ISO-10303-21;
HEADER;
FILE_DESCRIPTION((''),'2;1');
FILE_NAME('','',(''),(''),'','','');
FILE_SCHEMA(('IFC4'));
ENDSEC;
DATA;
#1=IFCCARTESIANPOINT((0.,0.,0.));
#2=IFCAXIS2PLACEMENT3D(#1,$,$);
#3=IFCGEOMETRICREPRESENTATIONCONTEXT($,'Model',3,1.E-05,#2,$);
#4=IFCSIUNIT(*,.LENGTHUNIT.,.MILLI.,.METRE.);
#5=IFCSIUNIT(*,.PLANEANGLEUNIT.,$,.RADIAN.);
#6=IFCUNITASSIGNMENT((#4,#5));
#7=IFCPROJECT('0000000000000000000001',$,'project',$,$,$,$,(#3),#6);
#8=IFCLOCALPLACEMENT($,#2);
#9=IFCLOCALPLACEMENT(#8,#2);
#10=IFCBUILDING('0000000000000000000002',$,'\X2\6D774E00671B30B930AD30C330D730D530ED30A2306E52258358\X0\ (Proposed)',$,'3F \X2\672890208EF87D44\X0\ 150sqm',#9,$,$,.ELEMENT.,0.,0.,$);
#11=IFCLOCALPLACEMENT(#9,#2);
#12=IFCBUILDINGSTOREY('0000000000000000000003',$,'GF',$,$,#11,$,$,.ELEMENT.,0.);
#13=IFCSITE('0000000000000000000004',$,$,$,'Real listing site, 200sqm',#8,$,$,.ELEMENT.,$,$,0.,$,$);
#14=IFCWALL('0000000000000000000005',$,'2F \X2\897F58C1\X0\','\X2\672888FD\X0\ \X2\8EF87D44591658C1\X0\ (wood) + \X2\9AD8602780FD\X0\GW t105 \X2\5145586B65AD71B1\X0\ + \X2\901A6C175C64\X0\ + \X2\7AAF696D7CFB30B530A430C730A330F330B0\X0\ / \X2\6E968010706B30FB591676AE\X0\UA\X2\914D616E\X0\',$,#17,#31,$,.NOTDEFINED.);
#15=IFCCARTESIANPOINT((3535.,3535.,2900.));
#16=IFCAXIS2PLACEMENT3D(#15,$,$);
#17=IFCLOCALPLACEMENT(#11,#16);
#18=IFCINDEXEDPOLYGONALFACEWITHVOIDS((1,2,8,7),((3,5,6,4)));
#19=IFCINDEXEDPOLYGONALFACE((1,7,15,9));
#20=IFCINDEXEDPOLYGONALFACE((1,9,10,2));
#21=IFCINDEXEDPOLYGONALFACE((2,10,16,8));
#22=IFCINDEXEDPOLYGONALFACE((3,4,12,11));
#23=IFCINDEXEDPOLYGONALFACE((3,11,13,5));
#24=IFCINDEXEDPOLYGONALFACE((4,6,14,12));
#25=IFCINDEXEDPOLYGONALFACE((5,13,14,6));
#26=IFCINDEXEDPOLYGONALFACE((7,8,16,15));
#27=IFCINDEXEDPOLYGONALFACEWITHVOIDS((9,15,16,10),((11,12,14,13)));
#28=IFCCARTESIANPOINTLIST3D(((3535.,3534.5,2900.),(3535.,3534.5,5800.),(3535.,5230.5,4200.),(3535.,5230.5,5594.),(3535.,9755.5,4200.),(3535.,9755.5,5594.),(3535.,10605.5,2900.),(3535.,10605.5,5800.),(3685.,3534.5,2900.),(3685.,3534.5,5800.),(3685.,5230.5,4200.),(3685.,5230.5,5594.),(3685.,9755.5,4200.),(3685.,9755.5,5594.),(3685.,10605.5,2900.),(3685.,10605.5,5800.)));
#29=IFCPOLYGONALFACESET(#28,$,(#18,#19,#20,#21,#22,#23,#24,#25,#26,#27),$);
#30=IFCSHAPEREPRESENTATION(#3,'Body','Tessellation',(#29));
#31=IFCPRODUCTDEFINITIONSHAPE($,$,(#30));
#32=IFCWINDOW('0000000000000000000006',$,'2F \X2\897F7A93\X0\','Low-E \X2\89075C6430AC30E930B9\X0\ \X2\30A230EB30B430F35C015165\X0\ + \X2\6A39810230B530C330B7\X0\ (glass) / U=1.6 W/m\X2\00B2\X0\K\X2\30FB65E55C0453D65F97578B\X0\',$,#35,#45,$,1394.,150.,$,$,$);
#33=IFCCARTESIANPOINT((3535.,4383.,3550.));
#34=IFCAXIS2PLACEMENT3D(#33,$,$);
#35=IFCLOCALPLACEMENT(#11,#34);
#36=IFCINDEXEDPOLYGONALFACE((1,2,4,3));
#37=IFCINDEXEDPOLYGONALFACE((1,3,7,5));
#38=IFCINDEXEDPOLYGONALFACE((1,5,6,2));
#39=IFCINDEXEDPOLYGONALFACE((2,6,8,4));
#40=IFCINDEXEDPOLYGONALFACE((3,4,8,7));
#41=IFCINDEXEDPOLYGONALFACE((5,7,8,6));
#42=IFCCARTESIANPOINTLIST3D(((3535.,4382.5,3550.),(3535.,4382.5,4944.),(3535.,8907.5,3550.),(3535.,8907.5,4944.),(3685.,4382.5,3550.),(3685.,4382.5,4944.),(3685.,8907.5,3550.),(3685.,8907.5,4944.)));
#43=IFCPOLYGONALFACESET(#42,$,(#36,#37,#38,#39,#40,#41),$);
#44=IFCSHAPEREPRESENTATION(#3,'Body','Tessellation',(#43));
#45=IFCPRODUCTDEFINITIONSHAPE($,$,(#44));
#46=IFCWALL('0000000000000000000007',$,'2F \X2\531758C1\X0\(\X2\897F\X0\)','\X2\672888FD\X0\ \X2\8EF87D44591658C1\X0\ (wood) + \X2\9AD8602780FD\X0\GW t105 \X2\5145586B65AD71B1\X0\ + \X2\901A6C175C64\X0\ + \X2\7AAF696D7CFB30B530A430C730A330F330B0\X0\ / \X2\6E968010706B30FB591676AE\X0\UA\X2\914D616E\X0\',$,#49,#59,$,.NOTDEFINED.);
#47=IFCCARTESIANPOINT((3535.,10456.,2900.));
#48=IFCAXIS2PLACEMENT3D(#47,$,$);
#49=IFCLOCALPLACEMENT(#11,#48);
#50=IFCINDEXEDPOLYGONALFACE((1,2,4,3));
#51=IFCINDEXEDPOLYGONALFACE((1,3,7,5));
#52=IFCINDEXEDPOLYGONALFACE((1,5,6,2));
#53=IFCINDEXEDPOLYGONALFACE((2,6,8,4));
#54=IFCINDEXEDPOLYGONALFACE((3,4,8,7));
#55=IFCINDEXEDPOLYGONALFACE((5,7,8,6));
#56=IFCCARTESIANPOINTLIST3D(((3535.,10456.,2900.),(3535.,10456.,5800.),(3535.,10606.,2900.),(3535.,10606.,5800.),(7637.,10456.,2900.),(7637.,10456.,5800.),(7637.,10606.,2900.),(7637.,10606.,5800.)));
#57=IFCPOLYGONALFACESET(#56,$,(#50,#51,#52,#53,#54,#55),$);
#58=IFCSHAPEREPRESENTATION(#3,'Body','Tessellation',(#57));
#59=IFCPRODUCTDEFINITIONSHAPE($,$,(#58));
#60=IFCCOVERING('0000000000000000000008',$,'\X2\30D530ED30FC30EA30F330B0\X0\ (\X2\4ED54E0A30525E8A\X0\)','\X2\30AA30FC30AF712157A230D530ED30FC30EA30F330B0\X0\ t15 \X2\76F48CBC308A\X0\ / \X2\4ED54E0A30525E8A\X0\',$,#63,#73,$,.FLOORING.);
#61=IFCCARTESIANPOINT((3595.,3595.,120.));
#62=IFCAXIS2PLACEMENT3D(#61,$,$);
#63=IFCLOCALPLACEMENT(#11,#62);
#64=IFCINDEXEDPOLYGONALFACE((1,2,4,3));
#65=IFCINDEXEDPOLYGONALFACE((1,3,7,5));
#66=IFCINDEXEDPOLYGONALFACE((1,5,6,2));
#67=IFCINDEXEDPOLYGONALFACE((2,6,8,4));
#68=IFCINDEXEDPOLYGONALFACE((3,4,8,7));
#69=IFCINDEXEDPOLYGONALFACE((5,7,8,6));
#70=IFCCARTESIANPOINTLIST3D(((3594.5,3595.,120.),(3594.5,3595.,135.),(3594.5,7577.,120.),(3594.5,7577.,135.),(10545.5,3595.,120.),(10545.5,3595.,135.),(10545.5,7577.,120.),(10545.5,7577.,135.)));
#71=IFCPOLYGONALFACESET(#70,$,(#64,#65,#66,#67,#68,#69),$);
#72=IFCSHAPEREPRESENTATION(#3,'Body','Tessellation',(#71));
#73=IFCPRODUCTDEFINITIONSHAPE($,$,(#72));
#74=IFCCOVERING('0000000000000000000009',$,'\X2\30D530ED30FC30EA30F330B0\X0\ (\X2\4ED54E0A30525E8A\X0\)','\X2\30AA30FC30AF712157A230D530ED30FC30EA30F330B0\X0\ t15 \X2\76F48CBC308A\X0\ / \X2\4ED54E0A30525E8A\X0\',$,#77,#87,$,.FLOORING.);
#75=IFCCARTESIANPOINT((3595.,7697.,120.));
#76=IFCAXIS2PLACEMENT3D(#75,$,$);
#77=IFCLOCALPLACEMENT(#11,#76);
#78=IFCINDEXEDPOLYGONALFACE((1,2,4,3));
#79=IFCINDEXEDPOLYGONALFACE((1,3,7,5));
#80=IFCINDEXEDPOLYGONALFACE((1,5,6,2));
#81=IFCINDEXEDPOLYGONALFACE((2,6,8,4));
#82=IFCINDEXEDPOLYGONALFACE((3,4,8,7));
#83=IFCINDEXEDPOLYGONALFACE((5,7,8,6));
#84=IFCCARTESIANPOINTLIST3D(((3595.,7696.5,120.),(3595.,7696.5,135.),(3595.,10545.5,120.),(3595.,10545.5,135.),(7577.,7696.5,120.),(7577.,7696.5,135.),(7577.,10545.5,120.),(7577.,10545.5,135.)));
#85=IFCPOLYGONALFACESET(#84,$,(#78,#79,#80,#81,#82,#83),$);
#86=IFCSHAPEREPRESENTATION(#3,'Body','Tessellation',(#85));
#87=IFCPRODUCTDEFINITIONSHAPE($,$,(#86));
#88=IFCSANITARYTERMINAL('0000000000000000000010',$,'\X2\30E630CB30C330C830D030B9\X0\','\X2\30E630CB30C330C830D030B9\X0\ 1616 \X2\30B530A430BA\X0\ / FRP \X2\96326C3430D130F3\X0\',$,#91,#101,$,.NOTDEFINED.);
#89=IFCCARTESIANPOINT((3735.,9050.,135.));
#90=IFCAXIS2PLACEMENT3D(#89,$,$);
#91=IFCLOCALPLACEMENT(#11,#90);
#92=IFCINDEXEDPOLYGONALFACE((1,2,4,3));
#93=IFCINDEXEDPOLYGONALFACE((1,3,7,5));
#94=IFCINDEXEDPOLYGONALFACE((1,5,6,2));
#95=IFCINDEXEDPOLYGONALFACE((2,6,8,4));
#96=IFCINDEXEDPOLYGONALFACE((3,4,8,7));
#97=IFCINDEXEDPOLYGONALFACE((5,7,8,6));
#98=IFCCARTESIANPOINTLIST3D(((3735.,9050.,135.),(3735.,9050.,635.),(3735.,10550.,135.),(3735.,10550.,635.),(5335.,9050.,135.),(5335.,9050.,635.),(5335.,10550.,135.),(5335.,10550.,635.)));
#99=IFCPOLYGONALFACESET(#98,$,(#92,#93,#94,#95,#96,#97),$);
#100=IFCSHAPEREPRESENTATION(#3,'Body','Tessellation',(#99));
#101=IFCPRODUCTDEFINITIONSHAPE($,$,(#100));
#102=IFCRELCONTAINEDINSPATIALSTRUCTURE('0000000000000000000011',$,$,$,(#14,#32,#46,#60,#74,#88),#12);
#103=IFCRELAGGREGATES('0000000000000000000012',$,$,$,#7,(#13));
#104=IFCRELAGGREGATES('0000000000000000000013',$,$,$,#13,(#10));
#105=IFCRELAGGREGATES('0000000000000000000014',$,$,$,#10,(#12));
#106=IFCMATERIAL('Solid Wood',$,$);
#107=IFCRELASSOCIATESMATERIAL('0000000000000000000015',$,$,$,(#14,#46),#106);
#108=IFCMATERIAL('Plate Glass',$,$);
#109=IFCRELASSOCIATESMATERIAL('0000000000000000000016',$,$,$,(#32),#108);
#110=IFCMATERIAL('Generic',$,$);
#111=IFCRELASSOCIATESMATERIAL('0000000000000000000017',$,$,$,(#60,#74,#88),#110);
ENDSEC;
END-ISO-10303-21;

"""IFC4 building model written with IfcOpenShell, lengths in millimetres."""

from ifc_helpers import new_model, si_unit, frame, frame_2d, origin, place, context, project, spatial, rectangle, extrude, material, element, fill, save


model = new_model("IFC4")

# Units and contexts
model_context = context("Model", 3, precision=1e-05, world=origin())
ifc_project = project(units=[si_unit("LENGTHUNIT", "METRE", prefix="MILLI"), si_unit("PLANEANGLEUNIT", "RADIAN")], contexts=[model_context])

# Site, building, storey
site_placement = place(None, origin())
site = spatial("IfcSite", under=ifc_project, at=site_placement, ObjectType="Real listing site, 200sqm", CompositionType="ELEMENT", RefElevation=0.0)
building_placement = place(site_placement, origin())
building = spatial("IfcBuilding", under=site, at=building_placement, Name="海一望スキップフロアの別荘 (Proposed)", ObjectType="3F 木造軸組 150sqm", CompositionType="ELEMENT", ElevationOfRefHeight=0.0, ElevationOfTerrain=0.0)
storey_placement = place(building_placement, origin())
storey = spatial("IfcBuildingStorey", under=building, at=storey_placement, Name="GF", CompositionType="ELEMENT", Elevation=0.0)

# Shared definitions
ifc_material_1 = material(Name="Solid Wood")

# Shared definitions
ifc_material_2 = material(Name="Plate Glass")

# Wall, opening, window
wall_1_placement = place(storey_placement, frame((3535.0, 3535.0, 2900.0)))
wall_1 = element("IfcWall", 1, at=wall_1_placement, inside=storey, material=ifc_material_1, Name="2F 西壁", Description="木製 軸組外壁 (wood) + 高性能GW t105 充填断熱 + 通気層 + 窯業系サイディング / 準耐火・外皮UA配慮", PredefinedType="NOTDEFINED", context=model_context, shape_type="SweptSolid", body=[
    extrude(rectangle(XDim=150.0, YDim=7071.0, at=frame_2d((75.0, 3535.0))), frame((3535.0, 3535.0, 2900.0)), (0.0, 0.0, 1.0), 2900.0),
])
opening_1_placement = place(storey_placement, frame((3535.0, 4383.0, 3550.0)))
opening_1 = element("IfcOpeningElement", 2, at=opening_1_placement, cuts=wall_1, PredefinedType="NOTDEFINED", context=model_context, shape_type="SweptSolid", body=[
    extrude(rectangle(XDim=150.0, YDim=4525.0, at=frame_2d((75.0, 2262.0))), frame((3535.0, 4383.0, 3550.0)), (0.0, 0.0, 1.0), 1394.0),
])
window_1_placement = place(storey_placement, frame((3535.0, 4383.0, 3550.0)))
window_1 = element("IfcWindow", 3, at=window_1_placement, inside=storey, material=ifc_material_2, Name="2F 西窓", Description="Low-E 複層ガラス アルゴン封入 + 樹脂サッシ (glass) / U=1.6 W/m²K・日射取得型", OverallHeight=1394.0, OverallWidth=150.0, context=model_context, shape_type="SweptSolid", body=[
    extrude(rectangle(XDim=150.0, YDim=4525.0, at=frame_2d((75.0, 2262.0))), frame((3535.0, 4383.0, 3550.0)), (0.0, 0.0, 1.0), 1394.0),
])
fill(opening_1, window_1)

# Wall
wall_2_placement = place(storey_placement, frame((3535.0, 10456.0, 2900.0)))
element("IfcWall", 4, at=wall_2_placement, inside=storey, material=ifc_material_1, Name="2F 北壁(西)", Description="木製 軸組外壁 (wood) + 高性能GW t105 充填断熱 + 通気層 + 窯業系サイディング / 準耐火・外皮UA配慮", PredefinedType="NOTDEFINED", context=model_context, shape_type="SweptSolid", body=[
    extrude(rectangle(XDim=4102.0, YDim=150.0, at=frame_2d((2051.0, 75.0))), frame((3535.0, 10456.0, 2900.0)), (0.0, 0.0, 1.0), 2900.0),
])

# Coverings
ifc_material_3 = material(Name="Generic")
covering_1_placement = place(storey_placement, frame((3595.0, 3595.0, 120.0)))
element("IfcCovering", 5, at=covering_1_placement, inside=storey, material=ifc_material_3, Name="フローリング (仕上げ床)", Description="オーク無垢フローリング t15 直貼り / 仕上げ床", PredefinedType="FLOORING", context=model_context, shape_type="SweptSolid", body=[
    extrude(rectangle(XDim=6951.0, YDim=3982.0, at=frame_2d((3475.0, 1991.0))), frame((3595.0, 3595.0, 120.0)), (0.0, 0.0, 1.0), 15.0),
])
covering_2_placement = place(storey_placement, frame((3595.0, 7697.0, 120.0)))
element("IfcCovering", 6, at=covering_2_placement, inside=storey, material=ifc_material_3, Name="フローリング (仕上げ床)", Description="オーク無垢フローリング t15 直貼り / 仕上げ床", PredefinedType="FLOORING", context=model_context, shape_type="SweptSolid", body=[
    extrude(rectangle(XDim=3982.0, YDim=2849.0, at=frame_2d((1991.0, 1424.0))), frame((3595.0, 7697.0, 120.0)), (0.0, 0.0, 1.0), 15.0),
])

# Sanitary terminal
sanitary_terminal_placement = place(storey_placement, frame((3735.0, 9050.0, 135.0)))
element("IfcSanitaryTerminal", 7, at=sanitary_terminal_placement, inside=storey, material=ifc_material_3, Name="ユニットバス", Description="ユニットバス 1616 サイズ / FRP 防水パン", PredefinedType="NOTDEFINED", context=model_context, shape_type="SweptSolid", body=[
    extrude(rectangle(XDim=1600.0, YDim=1500.0, at=frame_2d((800.0, 750.0))), frame((3735.0, 9050.0, 135.0)), (0.0, 0.0, 1.0), 500.0),
])

save(model, "model.ifc")
